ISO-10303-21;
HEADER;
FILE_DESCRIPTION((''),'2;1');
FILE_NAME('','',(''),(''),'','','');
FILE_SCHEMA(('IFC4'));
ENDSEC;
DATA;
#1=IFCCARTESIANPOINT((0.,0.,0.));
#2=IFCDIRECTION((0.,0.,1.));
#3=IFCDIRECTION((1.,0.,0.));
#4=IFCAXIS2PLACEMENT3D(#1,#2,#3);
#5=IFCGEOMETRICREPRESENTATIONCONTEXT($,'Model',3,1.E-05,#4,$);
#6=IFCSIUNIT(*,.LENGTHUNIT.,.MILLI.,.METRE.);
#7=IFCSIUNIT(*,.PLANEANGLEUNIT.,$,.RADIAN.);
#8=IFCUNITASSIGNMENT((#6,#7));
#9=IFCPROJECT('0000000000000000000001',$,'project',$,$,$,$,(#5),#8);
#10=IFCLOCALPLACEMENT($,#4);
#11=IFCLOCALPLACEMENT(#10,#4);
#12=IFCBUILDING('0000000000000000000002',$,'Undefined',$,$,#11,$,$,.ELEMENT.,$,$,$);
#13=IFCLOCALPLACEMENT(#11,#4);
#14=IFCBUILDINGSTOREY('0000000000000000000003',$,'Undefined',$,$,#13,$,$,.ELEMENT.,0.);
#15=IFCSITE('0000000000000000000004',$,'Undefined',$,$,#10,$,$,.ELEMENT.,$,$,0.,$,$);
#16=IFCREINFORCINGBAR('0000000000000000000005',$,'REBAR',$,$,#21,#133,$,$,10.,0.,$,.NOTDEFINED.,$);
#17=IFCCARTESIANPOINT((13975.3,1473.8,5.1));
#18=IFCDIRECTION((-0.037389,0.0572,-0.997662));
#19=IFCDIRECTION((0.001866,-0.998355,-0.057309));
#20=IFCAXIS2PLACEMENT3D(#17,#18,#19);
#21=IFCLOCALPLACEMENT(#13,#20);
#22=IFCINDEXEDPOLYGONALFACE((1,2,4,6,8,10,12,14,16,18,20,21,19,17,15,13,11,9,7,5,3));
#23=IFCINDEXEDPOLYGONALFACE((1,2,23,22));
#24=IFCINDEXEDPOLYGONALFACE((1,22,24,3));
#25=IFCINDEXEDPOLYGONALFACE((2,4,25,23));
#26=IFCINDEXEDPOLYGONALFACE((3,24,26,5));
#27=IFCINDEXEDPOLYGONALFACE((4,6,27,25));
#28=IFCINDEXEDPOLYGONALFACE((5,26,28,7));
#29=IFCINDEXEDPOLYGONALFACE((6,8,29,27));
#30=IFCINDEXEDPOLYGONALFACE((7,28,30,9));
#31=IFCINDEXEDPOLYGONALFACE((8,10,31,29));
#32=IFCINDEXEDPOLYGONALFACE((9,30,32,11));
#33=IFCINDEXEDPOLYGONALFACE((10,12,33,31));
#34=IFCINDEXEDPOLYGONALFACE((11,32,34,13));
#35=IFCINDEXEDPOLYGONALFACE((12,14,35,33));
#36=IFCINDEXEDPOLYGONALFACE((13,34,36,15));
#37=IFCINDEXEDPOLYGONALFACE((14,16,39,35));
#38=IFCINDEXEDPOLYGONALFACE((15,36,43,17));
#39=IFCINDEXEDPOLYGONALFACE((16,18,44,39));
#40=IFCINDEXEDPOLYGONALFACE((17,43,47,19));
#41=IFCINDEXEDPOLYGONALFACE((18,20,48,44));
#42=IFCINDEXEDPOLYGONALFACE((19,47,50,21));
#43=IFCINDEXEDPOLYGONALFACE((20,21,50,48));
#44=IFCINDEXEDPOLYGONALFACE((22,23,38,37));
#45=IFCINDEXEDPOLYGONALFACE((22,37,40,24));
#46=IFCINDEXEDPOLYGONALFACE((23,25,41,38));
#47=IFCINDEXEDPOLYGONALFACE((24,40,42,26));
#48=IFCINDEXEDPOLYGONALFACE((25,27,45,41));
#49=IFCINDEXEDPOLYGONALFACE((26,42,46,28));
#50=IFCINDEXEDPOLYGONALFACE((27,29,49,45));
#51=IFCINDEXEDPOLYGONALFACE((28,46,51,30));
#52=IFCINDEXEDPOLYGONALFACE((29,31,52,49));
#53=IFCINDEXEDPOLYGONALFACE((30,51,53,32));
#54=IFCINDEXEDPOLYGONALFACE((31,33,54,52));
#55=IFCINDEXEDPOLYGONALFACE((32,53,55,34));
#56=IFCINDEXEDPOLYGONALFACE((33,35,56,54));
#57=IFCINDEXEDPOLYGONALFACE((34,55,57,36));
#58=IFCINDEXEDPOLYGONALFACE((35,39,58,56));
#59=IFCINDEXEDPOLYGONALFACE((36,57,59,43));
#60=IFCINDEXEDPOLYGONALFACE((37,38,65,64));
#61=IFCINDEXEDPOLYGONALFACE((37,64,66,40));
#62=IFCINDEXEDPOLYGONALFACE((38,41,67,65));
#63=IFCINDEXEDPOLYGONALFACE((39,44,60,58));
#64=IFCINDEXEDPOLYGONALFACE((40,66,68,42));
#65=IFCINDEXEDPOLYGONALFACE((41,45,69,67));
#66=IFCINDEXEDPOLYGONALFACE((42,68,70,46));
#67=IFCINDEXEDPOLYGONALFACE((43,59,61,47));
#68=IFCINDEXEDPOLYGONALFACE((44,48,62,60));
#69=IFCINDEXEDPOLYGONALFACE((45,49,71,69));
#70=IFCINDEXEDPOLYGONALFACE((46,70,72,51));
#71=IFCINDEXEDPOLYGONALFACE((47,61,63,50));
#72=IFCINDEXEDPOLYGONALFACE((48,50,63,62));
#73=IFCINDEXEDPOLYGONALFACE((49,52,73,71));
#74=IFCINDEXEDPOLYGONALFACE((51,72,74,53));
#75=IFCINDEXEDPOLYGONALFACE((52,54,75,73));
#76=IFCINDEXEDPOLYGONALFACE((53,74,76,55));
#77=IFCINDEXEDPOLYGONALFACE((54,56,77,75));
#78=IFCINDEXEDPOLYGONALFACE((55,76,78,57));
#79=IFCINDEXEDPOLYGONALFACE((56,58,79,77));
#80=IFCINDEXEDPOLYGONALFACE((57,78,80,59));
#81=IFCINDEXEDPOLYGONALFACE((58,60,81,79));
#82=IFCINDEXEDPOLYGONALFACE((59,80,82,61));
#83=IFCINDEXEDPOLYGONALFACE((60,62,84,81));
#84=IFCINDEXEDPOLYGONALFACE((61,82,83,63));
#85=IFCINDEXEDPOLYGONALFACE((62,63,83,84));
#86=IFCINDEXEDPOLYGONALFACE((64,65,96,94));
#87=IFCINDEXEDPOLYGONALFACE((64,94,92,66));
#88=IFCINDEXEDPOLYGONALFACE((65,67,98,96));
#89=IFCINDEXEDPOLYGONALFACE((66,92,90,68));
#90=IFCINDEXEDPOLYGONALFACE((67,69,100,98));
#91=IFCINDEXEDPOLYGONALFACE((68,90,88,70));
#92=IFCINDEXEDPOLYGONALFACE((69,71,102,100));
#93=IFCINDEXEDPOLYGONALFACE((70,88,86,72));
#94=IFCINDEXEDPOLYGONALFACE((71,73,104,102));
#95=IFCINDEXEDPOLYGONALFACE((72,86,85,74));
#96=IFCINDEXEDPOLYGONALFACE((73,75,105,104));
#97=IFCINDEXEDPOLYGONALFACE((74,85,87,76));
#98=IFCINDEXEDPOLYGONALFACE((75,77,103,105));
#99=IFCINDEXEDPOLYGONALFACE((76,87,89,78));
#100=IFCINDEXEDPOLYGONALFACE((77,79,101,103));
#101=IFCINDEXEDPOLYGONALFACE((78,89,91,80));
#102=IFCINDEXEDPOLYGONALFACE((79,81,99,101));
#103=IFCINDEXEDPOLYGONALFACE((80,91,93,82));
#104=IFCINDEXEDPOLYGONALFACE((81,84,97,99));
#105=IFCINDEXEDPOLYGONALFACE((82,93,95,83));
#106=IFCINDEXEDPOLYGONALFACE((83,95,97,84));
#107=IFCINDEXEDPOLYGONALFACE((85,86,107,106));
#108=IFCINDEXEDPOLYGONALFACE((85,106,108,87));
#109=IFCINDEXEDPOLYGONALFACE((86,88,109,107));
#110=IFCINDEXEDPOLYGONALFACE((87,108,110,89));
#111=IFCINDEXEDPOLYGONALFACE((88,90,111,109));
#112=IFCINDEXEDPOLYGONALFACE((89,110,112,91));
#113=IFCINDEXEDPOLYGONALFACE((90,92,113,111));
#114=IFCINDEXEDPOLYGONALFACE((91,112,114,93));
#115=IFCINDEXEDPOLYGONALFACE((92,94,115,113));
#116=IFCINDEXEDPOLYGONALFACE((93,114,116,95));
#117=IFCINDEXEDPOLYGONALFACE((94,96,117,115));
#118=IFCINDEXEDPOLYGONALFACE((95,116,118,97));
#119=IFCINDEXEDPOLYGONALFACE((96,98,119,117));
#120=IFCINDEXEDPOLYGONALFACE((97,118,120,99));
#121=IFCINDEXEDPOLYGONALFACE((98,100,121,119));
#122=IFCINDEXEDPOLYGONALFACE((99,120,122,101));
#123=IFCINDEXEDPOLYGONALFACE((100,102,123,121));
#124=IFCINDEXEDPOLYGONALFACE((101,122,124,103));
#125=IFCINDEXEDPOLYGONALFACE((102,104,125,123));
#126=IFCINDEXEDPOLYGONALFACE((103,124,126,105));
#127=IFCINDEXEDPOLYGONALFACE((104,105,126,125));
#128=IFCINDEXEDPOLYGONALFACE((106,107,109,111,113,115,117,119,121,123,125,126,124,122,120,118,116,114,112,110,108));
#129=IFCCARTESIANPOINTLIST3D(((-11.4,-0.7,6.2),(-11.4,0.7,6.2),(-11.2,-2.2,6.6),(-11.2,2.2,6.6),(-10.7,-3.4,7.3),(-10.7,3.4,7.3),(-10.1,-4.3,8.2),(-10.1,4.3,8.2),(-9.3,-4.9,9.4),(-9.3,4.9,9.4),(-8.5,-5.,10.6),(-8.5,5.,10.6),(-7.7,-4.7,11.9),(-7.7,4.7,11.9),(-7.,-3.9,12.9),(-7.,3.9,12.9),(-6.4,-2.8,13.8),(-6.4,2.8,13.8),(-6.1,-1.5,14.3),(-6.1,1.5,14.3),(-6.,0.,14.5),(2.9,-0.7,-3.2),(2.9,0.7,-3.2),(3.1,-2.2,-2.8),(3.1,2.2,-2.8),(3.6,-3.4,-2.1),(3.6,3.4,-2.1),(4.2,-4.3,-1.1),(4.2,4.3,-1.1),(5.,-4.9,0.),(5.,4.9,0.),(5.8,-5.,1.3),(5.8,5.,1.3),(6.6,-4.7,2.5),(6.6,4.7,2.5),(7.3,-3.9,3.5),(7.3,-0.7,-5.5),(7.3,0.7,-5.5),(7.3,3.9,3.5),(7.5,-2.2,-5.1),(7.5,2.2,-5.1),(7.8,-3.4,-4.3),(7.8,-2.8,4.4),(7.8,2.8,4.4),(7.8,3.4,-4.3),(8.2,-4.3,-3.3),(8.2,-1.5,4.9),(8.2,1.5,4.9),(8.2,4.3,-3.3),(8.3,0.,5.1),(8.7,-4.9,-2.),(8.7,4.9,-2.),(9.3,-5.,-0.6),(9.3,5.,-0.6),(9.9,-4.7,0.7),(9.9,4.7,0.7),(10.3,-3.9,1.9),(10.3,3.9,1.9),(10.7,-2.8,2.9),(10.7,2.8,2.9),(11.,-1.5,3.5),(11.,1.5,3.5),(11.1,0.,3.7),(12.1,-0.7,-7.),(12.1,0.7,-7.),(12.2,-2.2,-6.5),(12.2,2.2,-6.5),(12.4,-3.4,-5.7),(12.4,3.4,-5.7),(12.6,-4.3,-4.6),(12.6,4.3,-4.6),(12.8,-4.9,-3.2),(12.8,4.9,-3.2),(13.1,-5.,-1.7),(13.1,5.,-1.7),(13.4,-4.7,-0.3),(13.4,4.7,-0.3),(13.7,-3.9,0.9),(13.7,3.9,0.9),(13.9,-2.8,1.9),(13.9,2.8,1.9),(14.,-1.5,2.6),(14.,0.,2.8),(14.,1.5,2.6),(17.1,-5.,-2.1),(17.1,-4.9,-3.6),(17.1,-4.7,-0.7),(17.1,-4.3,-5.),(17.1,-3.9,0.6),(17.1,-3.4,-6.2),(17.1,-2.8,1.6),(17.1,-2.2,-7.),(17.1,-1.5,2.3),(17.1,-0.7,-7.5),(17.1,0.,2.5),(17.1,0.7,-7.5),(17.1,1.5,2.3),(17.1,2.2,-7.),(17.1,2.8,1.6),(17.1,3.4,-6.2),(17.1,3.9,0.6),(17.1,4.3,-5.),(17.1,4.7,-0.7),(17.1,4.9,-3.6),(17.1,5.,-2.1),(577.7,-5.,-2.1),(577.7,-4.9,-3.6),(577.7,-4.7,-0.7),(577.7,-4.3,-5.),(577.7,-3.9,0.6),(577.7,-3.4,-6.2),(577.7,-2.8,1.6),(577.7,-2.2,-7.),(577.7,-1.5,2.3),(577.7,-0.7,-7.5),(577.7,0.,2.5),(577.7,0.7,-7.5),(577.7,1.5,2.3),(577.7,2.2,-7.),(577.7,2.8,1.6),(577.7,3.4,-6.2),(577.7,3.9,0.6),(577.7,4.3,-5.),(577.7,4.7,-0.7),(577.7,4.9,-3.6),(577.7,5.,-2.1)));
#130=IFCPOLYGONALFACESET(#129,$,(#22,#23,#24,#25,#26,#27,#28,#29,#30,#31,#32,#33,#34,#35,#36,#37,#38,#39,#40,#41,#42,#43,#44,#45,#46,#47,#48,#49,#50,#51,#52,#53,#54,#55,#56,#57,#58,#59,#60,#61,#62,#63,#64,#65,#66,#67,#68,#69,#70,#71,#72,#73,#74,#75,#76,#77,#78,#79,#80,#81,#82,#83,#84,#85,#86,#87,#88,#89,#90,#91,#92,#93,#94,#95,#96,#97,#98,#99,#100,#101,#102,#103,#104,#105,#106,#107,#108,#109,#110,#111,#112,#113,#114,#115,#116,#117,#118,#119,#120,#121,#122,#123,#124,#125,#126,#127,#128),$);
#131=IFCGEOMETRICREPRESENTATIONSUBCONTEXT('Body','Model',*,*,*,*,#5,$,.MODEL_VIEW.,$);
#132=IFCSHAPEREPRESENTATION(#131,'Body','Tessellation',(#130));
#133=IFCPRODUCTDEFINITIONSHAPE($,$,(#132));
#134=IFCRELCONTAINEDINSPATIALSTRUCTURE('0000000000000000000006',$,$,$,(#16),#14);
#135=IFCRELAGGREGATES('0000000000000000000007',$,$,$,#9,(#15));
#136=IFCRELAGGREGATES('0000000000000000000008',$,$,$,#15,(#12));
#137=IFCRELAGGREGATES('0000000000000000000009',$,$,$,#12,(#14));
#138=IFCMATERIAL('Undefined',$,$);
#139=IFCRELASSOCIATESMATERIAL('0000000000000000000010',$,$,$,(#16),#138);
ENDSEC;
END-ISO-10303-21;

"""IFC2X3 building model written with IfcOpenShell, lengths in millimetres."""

from ifc_helpers import new_model, entity, si_unit, frame, origin_with_axes, place, context, subcontext, project, spatial, source, transform, mapped, material, element, save


model = new_model("IFC2X3")

# Units and contexts
model_context = context("Model", 3, precision=1e-05, world=origin_with_axes())
body_context = subcontext(model_context, "Body", "Model", "MODEL_VIEW")
ifc_project = project(units=[si_unit("LENGTHUNIT", "METRE", prefix="MILLI"), si_unit("PLANEANGLEUNIT", "RADIAN")], contexts=[model_context])

# Site, building, storey
site_placement = place(None, origin_with_axes())
site = spatial("IfcSite", under=ifc_project, at=site_placement, Name="Undefined", CompositionType="ELEMENT", RefElevation=0.0)
building_placement = place(site_placement, origin_with_axes())
building = spatial("IfcBuilding", under=site, at=building_placement, Name="Undefined", CompositionType="ELEMENT")
storey_placement = place(building_placement, origin_with_axes())
storey = spatial("IfcBuildingStorey", under=building, at=storey_placement, Name="Undefined", CompositionType="ELEMENT", Elevation=0.0)

# Reinforcing bar
ifc_material_1 = material(Name="Undefined")
shared_shape_1 = source(origin_with_axes(), body_context, "Body", "AdvancedSweptSolid", [
    entity("IfcSweptDiskSolid", entity("IfcCompositeCurve", [entity("IfcCompositeCurveSegment", "CONTINUOUS", True, entity("IfcTrimmedCurve", entity("IfcLine", entity("IfcCartesianPoint", [0.0, 0.0, 0.0]), entity("IfcVector", entity("IfcDirection", [0.835483, 0.0, -0.549516]), 1.0)), [entity("IfcParameterValue", 0.0)], [entity("IfcParameterValue", 17.082101)], True, "PARAMETER")), entity("IfcCompositeCurveSegment", "CONTINUOUS", True, entity("IfcTrimmedCurve", entity("IfcCircle", entity("IfcAxis2Placement3D", entity("IfcCartesianPoint", [25.8, 0.0, 8.2]), entity("IfcDirection", [0.0, -1.0, 0.0]), entity("IfcDirection", [-0.549516, 0.0, -0.835483])), 21.0), [entity("IfcParameterValue", 0.0)], [entity("IfcParameterValue", 0.581785)], True, "PARAMETER")), entity("IfcCompositeCurveSegment", "DISCONTINUOUS", True, entity("IfcTrimmedCurve", entity("IfcLine", entity("IfcCartesianPoint", [25.8, 0.0, -12.8]), entity("IfcVector", entity("IfcDirection", [1.0, 0.0, 0.0]), 1.0)), [entity("IfcParameterValue", 0.0)], [entity("IfcParameterValue", 560.593055)], True, "PARAMETER"))], False), 5.0, None, 0.0, 578.3),
])
reinforcing_bar_1_placement = place(storey_placement, frame((13975.3, 1473.8, 5.1), z_axis=(-0.037389, 0.0572, -0.997662), x_axis=(0.001866, -0.998355, -0.057309)))
element("IfcReinforcingBar", 1, at=reinforcing_bar_1_placement, inside=storey, material=ifc_material_1, Name="REBAR", BarRole="NOTDEFINED", CrossSectionArea=0.0, NominalDiameter=10.0, context=body_context, shape_type="MappedRepresentation", body=[
    mapped(shared_shape_1, transform((-8.7, 0.0, 10.3))),
])

save(model, "model.ifc")
